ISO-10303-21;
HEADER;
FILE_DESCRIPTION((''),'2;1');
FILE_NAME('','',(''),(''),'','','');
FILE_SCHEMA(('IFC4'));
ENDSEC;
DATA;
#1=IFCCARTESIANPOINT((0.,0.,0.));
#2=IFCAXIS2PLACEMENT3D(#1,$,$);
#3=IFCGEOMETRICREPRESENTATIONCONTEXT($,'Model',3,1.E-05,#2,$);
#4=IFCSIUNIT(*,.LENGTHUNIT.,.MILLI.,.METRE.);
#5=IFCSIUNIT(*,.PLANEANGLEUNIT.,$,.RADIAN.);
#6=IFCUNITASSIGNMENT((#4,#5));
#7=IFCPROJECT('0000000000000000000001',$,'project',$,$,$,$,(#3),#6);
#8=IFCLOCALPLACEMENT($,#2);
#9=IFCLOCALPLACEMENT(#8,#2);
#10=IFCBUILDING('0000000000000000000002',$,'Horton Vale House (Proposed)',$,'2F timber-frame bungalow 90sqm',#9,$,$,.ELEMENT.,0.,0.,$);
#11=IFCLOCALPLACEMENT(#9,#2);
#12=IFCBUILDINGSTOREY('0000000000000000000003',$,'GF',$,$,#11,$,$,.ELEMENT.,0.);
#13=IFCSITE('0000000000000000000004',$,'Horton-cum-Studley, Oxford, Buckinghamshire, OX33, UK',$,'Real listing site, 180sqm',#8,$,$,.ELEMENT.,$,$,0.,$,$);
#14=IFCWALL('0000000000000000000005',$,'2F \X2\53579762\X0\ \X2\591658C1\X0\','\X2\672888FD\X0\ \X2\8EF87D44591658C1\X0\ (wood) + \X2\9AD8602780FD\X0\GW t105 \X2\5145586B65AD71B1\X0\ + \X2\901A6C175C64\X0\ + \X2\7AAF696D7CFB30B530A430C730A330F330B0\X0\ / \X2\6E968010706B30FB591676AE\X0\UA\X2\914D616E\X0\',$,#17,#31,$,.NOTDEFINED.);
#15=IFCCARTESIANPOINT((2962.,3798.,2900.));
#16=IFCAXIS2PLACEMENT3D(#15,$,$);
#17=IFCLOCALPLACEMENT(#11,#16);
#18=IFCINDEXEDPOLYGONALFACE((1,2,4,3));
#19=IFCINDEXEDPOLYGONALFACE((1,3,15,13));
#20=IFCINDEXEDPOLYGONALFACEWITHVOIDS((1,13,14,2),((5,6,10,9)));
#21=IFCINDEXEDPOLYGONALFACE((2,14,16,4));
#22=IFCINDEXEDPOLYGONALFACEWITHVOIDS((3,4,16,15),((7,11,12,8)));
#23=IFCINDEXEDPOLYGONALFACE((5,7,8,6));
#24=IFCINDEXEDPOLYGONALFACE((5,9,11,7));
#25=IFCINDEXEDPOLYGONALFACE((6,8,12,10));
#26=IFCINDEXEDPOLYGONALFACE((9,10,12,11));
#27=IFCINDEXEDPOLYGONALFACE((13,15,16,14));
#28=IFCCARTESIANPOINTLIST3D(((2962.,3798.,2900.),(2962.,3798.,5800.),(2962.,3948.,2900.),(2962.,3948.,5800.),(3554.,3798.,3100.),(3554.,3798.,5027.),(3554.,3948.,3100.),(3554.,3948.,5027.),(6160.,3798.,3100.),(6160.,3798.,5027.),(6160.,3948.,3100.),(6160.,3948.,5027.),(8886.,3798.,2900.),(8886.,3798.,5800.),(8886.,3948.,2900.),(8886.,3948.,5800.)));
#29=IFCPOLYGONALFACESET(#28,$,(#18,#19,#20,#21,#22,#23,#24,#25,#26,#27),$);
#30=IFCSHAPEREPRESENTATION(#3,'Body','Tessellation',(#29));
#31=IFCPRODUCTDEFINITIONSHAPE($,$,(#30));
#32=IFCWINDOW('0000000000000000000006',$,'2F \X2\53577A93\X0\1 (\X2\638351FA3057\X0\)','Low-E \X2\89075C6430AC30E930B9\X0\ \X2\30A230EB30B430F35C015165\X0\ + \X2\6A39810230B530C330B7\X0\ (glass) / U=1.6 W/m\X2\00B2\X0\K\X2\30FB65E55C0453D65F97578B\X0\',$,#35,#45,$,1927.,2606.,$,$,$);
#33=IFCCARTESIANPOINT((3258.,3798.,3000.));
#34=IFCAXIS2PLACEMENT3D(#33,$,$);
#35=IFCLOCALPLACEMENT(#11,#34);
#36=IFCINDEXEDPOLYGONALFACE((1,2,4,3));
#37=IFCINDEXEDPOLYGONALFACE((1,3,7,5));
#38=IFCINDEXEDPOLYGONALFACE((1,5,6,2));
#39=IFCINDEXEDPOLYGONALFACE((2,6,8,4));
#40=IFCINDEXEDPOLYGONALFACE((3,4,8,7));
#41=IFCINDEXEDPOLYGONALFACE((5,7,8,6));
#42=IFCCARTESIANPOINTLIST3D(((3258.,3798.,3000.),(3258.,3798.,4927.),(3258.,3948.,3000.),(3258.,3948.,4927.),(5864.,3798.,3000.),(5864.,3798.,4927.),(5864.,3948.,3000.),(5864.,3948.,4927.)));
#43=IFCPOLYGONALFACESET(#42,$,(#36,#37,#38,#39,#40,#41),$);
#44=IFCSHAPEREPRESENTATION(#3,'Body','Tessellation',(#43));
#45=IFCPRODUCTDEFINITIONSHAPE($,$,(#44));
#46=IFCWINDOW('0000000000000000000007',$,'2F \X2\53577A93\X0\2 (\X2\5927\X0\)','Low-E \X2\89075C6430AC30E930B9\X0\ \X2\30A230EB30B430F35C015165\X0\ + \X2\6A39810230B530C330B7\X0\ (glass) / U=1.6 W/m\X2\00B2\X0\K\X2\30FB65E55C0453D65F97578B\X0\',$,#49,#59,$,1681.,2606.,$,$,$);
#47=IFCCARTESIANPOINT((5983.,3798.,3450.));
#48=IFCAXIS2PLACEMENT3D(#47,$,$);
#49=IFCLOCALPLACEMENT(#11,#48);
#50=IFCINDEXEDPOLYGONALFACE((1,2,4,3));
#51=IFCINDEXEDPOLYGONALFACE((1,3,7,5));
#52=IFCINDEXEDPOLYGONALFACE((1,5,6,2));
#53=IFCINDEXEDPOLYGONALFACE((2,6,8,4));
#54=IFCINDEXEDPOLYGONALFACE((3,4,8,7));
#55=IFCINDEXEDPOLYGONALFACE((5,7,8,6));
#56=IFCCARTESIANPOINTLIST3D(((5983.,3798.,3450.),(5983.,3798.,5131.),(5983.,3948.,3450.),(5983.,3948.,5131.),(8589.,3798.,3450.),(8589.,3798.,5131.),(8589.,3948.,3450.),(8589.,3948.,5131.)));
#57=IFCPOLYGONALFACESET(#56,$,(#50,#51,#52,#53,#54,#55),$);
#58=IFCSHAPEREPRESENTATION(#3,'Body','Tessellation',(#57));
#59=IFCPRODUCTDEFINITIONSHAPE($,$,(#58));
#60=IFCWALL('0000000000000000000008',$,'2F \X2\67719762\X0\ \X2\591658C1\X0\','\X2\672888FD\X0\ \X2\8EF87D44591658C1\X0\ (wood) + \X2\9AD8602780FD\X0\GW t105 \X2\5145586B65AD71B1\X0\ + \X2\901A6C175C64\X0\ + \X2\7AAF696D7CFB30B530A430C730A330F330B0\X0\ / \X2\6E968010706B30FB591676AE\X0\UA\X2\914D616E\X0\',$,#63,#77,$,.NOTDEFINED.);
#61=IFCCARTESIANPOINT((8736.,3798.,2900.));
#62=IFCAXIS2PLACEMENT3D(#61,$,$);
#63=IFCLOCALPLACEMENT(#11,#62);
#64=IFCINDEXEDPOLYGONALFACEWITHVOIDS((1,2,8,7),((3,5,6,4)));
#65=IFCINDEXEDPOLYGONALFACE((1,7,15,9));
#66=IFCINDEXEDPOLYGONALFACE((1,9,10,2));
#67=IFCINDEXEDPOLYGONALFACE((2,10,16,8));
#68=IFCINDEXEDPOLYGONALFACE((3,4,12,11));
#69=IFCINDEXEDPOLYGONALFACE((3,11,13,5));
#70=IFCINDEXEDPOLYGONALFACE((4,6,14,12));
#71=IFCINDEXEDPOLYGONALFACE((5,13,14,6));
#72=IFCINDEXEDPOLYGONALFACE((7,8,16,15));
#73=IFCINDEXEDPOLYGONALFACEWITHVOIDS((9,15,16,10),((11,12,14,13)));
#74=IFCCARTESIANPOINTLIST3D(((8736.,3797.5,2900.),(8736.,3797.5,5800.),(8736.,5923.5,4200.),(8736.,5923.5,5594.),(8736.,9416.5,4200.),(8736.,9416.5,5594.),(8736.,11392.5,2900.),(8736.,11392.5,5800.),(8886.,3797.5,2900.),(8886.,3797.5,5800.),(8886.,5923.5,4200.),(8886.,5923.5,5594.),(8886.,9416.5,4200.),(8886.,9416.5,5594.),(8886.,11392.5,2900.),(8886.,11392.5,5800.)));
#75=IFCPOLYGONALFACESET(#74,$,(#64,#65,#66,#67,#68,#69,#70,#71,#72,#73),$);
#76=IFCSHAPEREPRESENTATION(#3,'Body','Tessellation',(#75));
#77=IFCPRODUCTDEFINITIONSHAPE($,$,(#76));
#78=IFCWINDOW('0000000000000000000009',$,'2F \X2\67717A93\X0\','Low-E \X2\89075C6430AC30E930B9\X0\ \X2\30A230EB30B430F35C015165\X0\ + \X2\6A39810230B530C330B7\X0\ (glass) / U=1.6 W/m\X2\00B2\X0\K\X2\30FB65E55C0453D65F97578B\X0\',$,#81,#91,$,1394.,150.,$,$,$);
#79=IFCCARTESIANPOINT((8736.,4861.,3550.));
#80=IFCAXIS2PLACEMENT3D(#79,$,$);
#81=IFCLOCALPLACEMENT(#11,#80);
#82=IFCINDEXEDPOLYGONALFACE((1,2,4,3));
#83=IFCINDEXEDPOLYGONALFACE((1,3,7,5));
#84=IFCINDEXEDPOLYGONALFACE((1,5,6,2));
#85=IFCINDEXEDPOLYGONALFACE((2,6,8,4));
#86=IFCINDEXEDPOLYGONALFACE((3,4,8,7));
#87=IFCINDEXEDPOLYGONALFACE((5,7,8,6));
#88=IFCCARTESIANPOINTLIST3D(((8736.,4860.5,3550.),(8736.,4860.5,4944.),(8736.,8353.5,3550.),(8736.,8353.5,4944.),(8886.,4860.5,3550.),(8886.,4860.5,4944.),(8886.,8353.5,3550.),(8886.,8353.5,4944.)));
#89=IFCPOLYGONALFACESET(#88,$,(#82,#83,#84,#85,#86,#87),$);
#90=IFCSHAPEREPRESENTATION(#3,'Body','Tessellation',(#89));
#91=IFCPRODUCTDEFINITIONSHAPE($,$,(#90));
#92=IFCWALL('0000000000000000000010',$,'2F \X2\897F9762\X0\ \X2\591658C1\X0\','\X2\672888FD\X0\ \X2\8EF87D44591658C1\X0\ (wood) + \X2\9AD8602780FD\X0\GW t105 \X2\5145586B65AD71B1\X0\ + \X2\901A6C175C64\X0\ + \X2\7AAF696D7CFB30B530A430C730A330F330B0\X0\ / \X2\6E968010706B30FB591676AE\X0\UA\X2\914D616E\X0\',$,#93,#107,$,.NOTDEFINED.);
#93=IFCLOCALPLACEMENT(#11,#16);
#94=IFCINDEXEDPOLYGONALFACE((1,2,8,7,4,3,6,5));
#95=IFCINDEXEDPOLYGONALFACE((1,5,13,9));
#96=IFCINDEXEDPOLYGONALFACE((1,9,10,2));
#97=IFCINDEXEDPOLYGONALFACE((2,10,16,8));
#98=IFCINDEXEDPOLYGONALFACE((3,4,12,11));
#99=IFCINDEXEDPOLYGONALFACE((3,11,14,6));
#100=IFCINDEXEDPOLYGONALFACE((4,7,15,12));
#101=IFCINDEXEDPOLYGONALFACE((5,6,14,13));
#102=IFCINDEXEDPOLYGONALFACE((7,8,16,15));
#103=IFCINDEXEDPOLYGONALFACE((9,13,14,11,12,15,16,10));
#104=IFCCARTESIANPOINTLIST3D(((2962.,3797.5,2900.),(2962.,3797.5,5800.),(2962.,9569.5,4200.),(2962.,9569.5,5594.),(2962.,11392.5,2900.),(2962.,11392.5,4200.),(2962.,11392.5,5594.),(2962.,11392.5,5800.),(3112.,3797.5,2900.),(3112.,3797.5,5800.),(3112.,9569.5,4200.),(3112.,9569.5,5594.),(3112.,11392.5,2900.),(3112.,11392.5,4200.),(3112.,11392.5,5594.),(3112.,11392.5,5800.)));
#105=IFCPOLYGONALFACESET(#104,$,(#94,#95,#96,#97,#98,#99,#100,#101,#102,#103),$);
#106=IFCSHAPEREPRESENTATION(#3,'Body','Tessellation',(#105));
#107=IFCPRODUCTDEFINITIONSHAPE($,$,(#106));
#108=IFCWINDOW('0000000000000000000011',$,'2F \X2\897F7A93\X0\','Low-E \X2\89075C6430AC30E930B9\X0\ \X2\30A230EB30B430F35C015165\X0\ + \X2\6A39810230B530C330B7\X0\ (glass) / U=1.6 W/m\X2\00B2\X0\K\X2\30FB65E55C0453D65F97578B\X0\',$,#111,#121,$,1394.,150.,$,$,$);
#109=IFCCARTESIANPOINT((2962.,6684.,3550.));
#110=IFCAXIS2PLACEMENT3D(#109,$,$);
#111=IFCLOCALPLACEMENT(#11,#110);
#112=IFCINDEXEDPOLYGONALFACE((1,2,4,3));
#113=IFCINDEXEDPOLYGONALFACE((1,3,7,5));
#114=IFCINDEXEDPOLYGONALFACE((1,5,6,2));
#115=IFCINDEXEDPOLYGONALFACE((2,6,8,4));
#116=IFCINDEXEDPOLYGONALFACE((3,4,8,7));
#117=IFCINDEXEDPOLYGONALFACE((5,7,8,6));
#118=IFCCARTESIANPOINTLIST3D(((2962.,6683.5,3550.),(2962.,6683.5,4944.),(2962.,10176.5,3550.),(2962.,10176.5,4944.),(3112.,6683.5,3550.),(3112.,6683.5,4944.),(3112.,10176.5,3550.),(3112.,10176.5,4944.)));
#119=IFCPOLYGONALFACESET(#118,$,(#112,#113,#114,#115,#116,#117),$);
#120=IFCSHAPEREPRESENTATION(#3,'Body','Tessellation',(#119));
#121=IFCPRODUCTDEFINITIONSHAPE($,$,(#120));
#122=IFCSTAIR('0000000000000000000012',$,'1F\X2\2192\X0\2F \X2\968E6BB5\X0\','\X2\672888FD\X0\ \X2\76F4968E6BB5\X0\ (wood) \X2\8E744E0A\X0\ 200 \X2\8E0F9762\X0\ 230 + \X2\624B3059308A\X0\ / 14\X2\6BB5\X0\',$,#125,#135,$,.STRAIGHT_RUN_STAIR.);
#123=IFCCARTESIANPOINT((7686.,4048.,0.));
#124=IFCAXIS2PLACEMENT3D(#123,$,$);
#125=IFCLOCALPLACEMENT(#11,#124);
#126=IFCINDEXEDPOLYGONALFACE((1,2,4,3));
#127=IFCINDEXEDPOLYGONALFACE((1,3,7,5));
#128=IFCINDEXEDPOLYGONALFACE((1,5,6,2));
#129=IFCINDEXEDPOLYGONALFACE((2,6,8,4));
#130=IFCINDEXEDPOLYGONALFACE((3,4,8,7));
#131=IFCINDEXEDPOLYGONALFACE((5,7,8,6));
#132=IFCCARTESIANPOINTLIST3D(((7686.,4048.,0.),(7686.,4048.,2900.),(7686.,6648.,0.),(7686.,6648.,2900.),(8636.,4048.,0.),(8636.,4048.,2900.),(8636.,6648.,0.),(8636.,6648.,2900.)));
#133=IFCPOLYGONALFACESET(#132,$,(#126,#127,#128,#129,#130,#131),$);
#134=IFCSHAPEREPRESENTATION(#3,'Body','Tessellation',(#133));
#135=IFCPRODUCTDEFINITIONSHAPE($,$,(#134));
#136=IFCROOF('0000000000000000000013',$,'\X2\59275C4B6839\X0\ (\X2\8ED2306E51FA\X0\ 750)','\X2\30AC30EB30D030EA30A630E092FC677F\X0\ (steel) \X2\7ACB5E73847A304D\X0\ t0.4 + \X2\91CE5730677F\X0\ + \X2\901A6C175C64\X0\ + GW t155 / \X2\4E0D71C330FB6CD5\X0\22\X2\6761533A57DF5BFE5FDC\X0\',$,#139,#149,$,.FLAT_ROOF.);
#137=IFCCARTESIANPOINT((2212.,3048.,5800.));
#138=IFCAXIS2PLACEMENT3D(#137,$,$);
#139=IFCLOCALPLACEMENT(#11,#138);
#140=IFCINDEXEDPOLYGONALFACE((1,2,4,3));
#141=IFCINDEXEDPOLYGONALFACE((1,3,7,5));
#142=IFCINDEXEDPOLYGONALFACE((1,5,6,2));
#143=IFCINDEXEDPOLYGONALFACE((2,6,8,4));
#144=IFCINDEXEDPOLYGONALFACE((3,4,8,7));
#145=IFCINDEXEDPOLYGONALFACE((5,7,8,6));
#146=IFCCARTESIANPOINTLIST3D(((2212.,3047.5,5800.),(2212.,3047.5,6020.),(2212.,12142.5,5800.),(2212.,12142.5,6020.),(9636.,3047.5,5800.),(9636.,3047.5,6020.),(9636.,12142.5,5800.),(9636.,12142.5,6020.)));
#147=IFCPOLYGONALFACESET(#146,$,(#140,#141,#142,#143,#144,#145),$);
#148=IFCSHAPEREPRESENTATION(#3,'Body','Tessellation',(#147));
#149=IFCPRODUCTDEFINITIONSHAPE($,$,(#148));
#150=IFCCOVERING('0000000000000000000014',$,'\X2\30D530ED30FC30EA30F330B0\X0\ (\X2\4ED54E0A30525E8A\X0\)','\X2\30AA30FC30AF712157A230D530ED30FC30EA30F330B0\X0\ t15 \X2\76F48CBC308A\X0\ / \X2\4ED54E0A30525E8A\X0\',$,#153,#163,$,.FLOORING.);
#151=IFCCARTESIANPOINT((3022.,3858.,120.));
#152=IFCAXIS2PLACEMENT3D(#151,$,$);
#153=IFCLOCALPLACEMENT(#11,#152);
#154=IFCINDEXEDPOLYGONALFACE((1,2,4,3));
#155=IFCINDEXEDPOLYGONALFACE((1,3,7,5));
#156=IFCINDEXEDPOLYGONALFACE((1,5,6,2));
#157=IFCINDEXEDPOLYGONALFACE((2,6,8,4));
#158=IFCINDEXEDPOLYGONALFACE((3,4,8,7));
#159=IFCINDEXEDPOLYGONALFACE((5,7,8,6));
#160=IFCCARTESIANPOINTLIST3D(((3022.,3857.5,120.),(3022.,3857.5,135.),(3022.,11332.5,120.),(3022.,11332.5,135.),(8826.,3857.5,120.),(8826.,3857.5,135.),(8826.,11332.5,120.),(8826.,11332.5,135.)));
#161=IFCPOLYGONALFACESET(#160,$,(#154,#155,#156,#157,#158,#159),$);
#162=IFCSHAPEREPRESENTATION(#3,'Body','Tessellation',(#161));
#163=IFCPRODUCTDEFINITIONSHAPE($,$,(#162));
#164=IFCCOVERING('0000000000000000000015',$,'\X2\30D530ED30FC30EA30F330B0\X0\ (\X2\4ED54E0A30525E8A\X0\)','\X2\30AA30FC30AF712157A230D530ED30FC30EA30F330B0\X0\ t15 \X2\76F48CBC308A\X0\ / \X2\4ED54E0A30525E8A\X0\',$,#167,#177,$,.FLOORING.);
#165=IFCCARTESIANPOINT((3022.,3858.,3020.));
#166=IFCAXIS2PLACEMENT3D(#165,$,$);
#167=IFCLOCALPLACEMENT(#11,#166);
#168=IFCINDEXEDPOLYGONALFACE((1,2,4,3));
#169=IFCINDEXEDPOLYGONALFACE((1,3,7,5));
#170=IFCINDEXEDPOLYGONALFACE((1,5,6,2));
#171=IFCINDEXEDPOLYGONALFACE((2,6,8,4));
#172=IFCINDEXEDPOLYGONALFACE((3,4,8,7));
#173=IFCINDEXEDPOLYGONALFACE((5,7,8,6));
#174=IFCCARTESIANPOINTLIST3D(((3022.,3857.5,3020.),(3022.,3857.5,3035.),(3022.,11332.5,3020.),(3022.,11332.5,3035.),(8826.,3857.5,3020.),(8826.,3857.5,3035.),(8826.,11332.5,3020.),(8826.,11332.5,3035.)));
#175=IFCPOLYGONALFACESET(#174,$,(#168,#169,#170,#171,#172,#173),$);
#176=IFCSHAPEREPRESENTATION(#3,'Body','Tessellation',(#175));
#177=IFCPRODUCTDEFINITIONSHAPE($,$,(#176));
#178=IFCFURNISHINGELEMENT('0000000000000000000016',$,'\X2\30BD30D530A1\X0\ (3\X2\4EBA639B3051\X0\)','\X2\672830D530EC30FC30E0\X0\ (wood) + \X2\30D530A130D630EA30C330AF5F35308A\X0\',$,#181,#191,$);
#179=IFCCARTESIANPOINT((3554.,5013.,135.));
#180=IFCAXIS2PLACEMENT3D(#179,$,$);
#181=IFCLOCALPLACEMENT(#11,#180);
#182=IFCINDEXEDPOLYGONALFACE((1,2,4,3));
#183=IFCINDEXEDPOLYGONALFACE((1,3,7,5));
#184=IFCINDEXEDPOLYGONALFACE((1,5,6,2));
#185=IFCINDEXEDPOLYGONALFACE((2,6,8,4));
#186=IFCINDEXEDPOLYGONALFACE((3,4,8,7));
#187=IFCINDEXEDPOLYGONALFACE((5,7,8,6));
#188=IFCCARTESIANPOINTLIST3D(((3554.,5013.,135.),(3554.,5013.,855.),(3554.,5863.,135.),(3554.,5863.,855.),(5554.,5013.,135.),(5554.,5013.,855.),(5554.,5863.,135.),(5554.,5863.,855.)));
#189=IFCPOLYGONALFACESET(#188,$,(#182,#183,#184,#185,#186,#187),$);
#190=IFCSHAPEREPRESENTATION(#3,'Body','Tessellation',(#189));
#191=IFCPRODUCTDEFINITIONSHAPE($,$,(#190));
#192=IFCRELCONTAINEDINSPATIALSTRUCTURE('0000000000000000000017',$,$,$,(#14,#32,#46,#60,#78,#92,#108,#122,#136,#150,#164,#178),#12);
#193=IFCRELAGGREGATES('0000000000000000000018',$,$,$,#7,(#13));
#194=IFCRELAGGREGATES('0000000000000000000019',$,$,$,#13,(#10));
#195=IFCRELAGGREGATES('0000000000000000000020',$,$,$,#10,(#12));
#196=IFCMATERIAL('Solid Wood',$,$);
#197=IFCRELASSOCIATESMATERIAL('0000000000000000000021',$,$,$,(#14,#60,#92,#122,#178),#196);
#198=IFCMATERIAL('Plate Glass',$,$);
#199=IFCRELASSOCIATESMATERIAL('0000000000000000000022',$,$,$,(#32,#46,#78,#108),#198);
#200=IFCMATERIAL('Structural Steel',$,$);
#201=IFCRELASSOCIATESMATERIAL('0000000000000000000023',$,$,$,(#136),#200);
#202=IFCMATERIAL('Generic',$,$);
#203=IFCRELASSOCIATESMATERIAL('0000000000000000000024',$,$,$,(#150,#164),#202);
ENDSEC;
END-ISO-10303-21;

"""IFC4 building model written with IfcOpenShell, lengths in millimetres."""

from ifc_helpers import new_model, si_unit, frame, frame_2d, origin, place, context, project, spatial, rectangle, extrude, material, element, fill, save


model = new_model("IFC4")

# Units and contexts
model_context = context("Model", 3, precision=1e-05, world=origin())
ifc_project = project(units=[si_unit("LENGTHUNIT", "METRE", prefix="MILLI"), si_unit("PLANEANGLEUNIT", "RADIAN")], contexts=[model_context])

# Site, building, storey
site_placement = place(None, origin())
site = spatial("IfcSite", under=ifc_project, at=site_placement, Name="Horton-cum-Studley, Oxford, Buckinghamshire, OX33, UK", ObjectType="Real listing site, 180sqm", CompositionType="ELEMENT", RefElevation=0.0)
building_placement = place(site_placement, origin())
building = spatial("IfcBuilding", under=site, at=building_placement, Name="Horton Vale House (Proposed)", ObjectType="2F timber-frame bungalow 90sqm", CompositionType="ELEMENT", ElevationOfRefHeight=0.0, ElevationOfTerrain=0.0)
storey_placement = place(building_placement, origin())
storey = spatial("IfcBuildingStorey", under=building, at=storey_placement, Name="GF", CompositionType="ELEMENT", Elevation=0.0)

# Shared definitions
ifc_material_1 = material(Name="Solid Wood")

# Shared definitions
ifc_material_2 = material(Name="Plate Glass")

# Wall, openings, windows
wall_1_placement = place(storey_placement, frame((2962.0, 3798.0, 2900.0)))
wall_1 = element("IfcWall", 1, at=wall_1_placement, inside=storey, material=ifc_material_1, Name="2F 南面 外壁", Description="木製 軸組外壁 (wood) + 高性能GW t105 充填断熱 + 通気層 + 窯業系サイディング / 準耐火・外皮UA配慮", PredefinedType="NOTDEFINED", context=model_context, shape_type="SweptSolid", body=[
    extrude(rectangle(XDim=5924.0, YDim=150.0, at=frame_2d((2962.0, 75.0))), frame((2962.0, 3798.0, 2900.0)), (0.0, 0.0, 1.0), 2900.0),
])
opening_1_placement = place(storey_placement, frame((3258.0, 3798.0, 3000.0)))
opening_1 = element("IfcOpeningElement", 2, at=opening_1_placement, cuts=wall_1, PredefinedType="NOTDEFINED", context=model_context, shape_type="SweptSolid", body=[
    extrude(rectangle(XDim=2606.0, YDim=150.0, at=frame_2d((1303.0, 75.0))), frame((3258.0, 3798.0, 3000.0)), (0.0, 0.0, 1.0), 1927.0),
])
opening_2_placement = place(storey_placement, frame((5983.0, 3798.0, 3450.0)))
opening_2 = element("IfcOpeningElement", 3, at=opening_2_placement, cuts=wall_1, PredefinedType="NOTDEFINED", context=model_context, shape_type="SweptSolid", body=[
    extrude(rectangle(XDim=2606.0, YDim=150.0, at=frame_2d((1303.0, 75.0))), frame((5983.0, 3798.0, 3450.0)), (0.0, 0.0, 1.0), 1681.0),
])
window_1_placement = place(storey_placement, frame((3258.0, 3798.0, 3000.0)))
window_1 = element("IfcWindow", 4, at=window_1_placement, inside=storey, material=ifc_material_2, Name="2F 南窓1 (掃出し)", Description="Low-E 複層ガラス アルゴン封入 + 樹脂サッシ (glass) / U=1.6 W/m²K・日射取得型", OverallHeight=1927.0, OverallWidth=2606.0, context=model_context, shape_type="SweptSolid", body=[
    extrude(rectangle(XDim=2606.0, YDim=150.0, at=frame_2d((1303.0, 75.0))), frame((3258.0, 3798.0, 3000.0)), (0.0, 0.0, 1.0), 1927.0),
])
fill(opening_1, window_1)
window_2_placement = place(storey_placement, frame((5983.0, 3798.0, 3450.0)))
window_2 = element("IfcWindow", 5, at=window_2_placement, inside=storey, material=ifc_material_2, Name="2F 南窓2 (大)", Description="Low-E 複層ガラス アルゴン封入 + 樹脂サッシ (glass) / U=1.6 W/m²K・日射取得型", OverallHeight=1681.0, OverallWidth=2606.0, context=model_context, shape_type="SweptSolid", body=[
    extrude(rectangle(XDim=2606.0, YDim=150.0, at=frame_2d((1303.0, 75.0))), frame((5983.0, 3798.0, 3450.0)), (0.0, 0.0, 1.0), 1681.0),
])
fill(opening_2, window_2)

# Walls, openings, windows
wall_2_placement = place(storey_placement, frame((8736.0, 3798.0, 2900.0)))
wall_2 = element("IfcWall", 6, at=wall_2_placement, inside=storey, material=ifc_material_1, Name="2F 東面 外壁", Description="木製 軸組外壁 (wood) + 高性能GW t105 充填断熱 + 通気層 + 窯業系サイディング / 準耐火・外皮UA配慮", PredefinedType="NOTDEFINED", context=model_context, shape_type="SweptSolid", body=[
    extrude(rectangle(XDim=150.0, YDim=7595.0, at=frame_2d((75.0, 3797.0))), frame((8736.0, 3798.0, 2900.0)), (0.0, 0.0, 1.0), 2900.0),
])
opening_3_placement = place(storey_placement, frame((8736.0, 4861.0, 3550.0)))
opening_3 = element("IfcOpeningElement", 7, at=opening_3_placement, cuts=wall_2, PredefinedType="NOTDEFINED", context=model_context, shape_type="SweptSolid", body=[
    extrude(rectangle(XDim=150.0, YDim=3493.0, at=frame_2d((75.0, 1746.0))), frame((8736.0, 4861.0, 3550.0)), (0.0, 0.0, 1.0), 1394.0),
])
window_3_placement = place(storey_placement, frame((8736.0, 4861.0, 3550.0)))
window_3 = element("IfcWindow", 8, at=window_3_placement, inside=storey, material=ifc_material_2, Name="2F 東窓", Description="Low-E 複層ガラス アルゴン封入 + 樹脂サッシ (glass) / U=1.6 W/m²K・日射取得型", OverallHeight=1394.0, OverallWidth=150.0, context=model_context, shape_type="SweptSolid", body=[
    extrude(rectangle(XDim=150.0, YDim=3493.0, at=frame_2d((75.0, 1746.0))), frame((8736.0, 4861.0, 3550.0)), (0.0, 0.0, 1.0), 1394.0),
])
fill(opening_3, window_3)
wall_3_placement = place(storey_placement, frame((2962.0, 3798.0, 2900.0)))
wall_3 = element("IfcWall", 9, at=wall_3_placement, inside=storey, material=ifc_material_1, Name="2F 西面 外壁", Description="木製 軸組外壁 (wood) + 高性能GW t105 充填断熱 + 通気層 + 窯業系サイディング / 準耐火・外皮UA配慮", PredefinedType="NOTDEFINED", context=model_context, shape_type="SweptSolid", body=[
    extrude(rectangle(XDim=150.0, YDim=7595.0, at=frame_2d((75.0, 3797.0))), frame((2962.0, 3798.0, 2900.0)), (0.0, 0.0, 1.0), 2900.0),
])
opening_4_placement = place(storey_placement, frame((2962.0, 6684.0, 3550.0)))
opening_4 = element("IfcOpeningElement", 10, at=opening_4_placement, cuts=wall_3, PredefinedType="NOTDEFINED", context=model_context, shape_type="SweptSolid", body=[
    extrude(rectangle(XDim=150.0, YDim=3493.0, at=frame_2d((75.0, 1746.0))), frame((2962.0, 6684.0, 3550.0)), (0.0, 0.0, 1.0), 1394.0),
])
window_4_placement = place(storey_placement, frame((2962.0, 6684.0, 3550.0)))
window_4 = element("IfcWindow", 11, at=window_4_placement, inside=storey, material=ifc_material_2, Name="2F 西窓", Description="Low-E 複層ガラス アルゴン封入 + 樹脂サッシ (glass) / U=1.6 W/m²K・日射取得型", OverallHeight=1394.0, OverallWidth=150.0, context=model_context, shape_type="SweptSolid", body=[
    extrude(rectangle(XDim=150.0, YDim=3493.0, at=frame_2d((75.0, 1746.0))), frame((2962.0, 6684.0, 3550.0)), (0.0, 0.0, 1.0), 1394.0),
])
fill(opening_4, window_4)

# Stair
stair_placement = place(storey_placement, frame((7686.0, 4048.0, 0.0)))
element("IfcStair", 12, at=stair_placement, inside=storey, material=ifc_material_1, Name="1F→2F 階段", Description="木製 直階段 (wood) 蹴上 200 踏面 230 + 手すり / 14段", PredefinedType="STRAIGHT_RUN_STAIR", context=model_context, shape_type="SweptSolid", body=[
    extrude(rectangle(XDim=950.0, YDim=2600.0, at=frame_2d((475.0, 1300.0))), frame((7686.0, 4048.0, 0.0)), (0.0, 0.0, 1.0), 2900.0),
])

# Roof
ifc_material_3 = material(Name="Structural Steel")
roof_placement = place(storey_placement, frame((2212.0, 3048.0, 5800.0)))
element("IfcRoof", 13, at=roof_placement, inside=storey, material=ifc_material_3, Name="大屋根 (軒の出 750)", Description="ガルバリウム鋼板 (steel) 立平葺き t0.4 + 野地板 + 通気層 + GW t155 / 不燃・法22条区域対応", PredefinedType="FLAT_ROOF", context=model_context, shape_type="SweptSolid", body=[
    extrude(rectangle(XDim=7424.0, YDim=9095.0, at=frame_2d((3712.0, 4547.0))), frame((2212.0, 3048.0, 5800.0)), (0.0, 0.0, 1.0), 220.0),
])

# Coverings
ifc_material_4 = material(Name="Generic")
covering_1_placement = place(storey_placement, frame((3022.0, 3858.0, 120.0)))
element("IfcCovering", 14, at=covering_1_placement, inside=storey, material=ifc_material_4, Name="フローリング (仕上げ床)", Description="オーク無垢フローリング t15 直貼り / 仕上げ床", PredefinedType="FLOORING", context=model_context, shape_type="SweptSolid", body=[
    extrude(rectangle(XDim=5804.0, YDim=7475.0, at=frame_2d((2902.0, 3737.0))), frame((3022.0, 3858.0, 120.0)), (0.0, 0.0, 1.0), 15.0),
])
covering_2_placement = place(storey_placement, frame((3022.0, 3858.0, 3020.0)))
element("IfcCovering", 15, at=covering_2_placement, inside=storey, material=ifc_material_4, Name="フローリング (仕上げ床)", Description="オーク無垢フローリング t15 直貼り / 仕上げ床", PredefinedType="FLOORING", context=model_context, shape_type="SweptSolid", body=[
    extrude(rectangle(XDim=5804.0, YDim=7475.0, at=frame_2d((2902.0, 3737.0))), frame((3022.0, 3858.0, 3020.0)), (0.0, 0.0, 1.0), 15.0),
])

# Furnishing element
furnishing_1_placement = place(storey_placement, frame((3554.0, 5013.0, 135.0)))
element("IfcFurnishingElement", 16, at=furnishing_1_placement, inside=storey, material=ifc_material_1, Name="ソファ (3人掛け)", Description="木フレーム (wood) + ファブリック張り", context=model_context, shape_type="SweptSolid", body=[
    extrude(rectangle(XDim=2000.0, YDim=850.0, at=frame_2d((1000.0, 425.0))), frame((3554.0, 5013.0, 135.0)), (0.0, 0.0, 1.0), 720.0),
])

save(model, "model.ifc")
